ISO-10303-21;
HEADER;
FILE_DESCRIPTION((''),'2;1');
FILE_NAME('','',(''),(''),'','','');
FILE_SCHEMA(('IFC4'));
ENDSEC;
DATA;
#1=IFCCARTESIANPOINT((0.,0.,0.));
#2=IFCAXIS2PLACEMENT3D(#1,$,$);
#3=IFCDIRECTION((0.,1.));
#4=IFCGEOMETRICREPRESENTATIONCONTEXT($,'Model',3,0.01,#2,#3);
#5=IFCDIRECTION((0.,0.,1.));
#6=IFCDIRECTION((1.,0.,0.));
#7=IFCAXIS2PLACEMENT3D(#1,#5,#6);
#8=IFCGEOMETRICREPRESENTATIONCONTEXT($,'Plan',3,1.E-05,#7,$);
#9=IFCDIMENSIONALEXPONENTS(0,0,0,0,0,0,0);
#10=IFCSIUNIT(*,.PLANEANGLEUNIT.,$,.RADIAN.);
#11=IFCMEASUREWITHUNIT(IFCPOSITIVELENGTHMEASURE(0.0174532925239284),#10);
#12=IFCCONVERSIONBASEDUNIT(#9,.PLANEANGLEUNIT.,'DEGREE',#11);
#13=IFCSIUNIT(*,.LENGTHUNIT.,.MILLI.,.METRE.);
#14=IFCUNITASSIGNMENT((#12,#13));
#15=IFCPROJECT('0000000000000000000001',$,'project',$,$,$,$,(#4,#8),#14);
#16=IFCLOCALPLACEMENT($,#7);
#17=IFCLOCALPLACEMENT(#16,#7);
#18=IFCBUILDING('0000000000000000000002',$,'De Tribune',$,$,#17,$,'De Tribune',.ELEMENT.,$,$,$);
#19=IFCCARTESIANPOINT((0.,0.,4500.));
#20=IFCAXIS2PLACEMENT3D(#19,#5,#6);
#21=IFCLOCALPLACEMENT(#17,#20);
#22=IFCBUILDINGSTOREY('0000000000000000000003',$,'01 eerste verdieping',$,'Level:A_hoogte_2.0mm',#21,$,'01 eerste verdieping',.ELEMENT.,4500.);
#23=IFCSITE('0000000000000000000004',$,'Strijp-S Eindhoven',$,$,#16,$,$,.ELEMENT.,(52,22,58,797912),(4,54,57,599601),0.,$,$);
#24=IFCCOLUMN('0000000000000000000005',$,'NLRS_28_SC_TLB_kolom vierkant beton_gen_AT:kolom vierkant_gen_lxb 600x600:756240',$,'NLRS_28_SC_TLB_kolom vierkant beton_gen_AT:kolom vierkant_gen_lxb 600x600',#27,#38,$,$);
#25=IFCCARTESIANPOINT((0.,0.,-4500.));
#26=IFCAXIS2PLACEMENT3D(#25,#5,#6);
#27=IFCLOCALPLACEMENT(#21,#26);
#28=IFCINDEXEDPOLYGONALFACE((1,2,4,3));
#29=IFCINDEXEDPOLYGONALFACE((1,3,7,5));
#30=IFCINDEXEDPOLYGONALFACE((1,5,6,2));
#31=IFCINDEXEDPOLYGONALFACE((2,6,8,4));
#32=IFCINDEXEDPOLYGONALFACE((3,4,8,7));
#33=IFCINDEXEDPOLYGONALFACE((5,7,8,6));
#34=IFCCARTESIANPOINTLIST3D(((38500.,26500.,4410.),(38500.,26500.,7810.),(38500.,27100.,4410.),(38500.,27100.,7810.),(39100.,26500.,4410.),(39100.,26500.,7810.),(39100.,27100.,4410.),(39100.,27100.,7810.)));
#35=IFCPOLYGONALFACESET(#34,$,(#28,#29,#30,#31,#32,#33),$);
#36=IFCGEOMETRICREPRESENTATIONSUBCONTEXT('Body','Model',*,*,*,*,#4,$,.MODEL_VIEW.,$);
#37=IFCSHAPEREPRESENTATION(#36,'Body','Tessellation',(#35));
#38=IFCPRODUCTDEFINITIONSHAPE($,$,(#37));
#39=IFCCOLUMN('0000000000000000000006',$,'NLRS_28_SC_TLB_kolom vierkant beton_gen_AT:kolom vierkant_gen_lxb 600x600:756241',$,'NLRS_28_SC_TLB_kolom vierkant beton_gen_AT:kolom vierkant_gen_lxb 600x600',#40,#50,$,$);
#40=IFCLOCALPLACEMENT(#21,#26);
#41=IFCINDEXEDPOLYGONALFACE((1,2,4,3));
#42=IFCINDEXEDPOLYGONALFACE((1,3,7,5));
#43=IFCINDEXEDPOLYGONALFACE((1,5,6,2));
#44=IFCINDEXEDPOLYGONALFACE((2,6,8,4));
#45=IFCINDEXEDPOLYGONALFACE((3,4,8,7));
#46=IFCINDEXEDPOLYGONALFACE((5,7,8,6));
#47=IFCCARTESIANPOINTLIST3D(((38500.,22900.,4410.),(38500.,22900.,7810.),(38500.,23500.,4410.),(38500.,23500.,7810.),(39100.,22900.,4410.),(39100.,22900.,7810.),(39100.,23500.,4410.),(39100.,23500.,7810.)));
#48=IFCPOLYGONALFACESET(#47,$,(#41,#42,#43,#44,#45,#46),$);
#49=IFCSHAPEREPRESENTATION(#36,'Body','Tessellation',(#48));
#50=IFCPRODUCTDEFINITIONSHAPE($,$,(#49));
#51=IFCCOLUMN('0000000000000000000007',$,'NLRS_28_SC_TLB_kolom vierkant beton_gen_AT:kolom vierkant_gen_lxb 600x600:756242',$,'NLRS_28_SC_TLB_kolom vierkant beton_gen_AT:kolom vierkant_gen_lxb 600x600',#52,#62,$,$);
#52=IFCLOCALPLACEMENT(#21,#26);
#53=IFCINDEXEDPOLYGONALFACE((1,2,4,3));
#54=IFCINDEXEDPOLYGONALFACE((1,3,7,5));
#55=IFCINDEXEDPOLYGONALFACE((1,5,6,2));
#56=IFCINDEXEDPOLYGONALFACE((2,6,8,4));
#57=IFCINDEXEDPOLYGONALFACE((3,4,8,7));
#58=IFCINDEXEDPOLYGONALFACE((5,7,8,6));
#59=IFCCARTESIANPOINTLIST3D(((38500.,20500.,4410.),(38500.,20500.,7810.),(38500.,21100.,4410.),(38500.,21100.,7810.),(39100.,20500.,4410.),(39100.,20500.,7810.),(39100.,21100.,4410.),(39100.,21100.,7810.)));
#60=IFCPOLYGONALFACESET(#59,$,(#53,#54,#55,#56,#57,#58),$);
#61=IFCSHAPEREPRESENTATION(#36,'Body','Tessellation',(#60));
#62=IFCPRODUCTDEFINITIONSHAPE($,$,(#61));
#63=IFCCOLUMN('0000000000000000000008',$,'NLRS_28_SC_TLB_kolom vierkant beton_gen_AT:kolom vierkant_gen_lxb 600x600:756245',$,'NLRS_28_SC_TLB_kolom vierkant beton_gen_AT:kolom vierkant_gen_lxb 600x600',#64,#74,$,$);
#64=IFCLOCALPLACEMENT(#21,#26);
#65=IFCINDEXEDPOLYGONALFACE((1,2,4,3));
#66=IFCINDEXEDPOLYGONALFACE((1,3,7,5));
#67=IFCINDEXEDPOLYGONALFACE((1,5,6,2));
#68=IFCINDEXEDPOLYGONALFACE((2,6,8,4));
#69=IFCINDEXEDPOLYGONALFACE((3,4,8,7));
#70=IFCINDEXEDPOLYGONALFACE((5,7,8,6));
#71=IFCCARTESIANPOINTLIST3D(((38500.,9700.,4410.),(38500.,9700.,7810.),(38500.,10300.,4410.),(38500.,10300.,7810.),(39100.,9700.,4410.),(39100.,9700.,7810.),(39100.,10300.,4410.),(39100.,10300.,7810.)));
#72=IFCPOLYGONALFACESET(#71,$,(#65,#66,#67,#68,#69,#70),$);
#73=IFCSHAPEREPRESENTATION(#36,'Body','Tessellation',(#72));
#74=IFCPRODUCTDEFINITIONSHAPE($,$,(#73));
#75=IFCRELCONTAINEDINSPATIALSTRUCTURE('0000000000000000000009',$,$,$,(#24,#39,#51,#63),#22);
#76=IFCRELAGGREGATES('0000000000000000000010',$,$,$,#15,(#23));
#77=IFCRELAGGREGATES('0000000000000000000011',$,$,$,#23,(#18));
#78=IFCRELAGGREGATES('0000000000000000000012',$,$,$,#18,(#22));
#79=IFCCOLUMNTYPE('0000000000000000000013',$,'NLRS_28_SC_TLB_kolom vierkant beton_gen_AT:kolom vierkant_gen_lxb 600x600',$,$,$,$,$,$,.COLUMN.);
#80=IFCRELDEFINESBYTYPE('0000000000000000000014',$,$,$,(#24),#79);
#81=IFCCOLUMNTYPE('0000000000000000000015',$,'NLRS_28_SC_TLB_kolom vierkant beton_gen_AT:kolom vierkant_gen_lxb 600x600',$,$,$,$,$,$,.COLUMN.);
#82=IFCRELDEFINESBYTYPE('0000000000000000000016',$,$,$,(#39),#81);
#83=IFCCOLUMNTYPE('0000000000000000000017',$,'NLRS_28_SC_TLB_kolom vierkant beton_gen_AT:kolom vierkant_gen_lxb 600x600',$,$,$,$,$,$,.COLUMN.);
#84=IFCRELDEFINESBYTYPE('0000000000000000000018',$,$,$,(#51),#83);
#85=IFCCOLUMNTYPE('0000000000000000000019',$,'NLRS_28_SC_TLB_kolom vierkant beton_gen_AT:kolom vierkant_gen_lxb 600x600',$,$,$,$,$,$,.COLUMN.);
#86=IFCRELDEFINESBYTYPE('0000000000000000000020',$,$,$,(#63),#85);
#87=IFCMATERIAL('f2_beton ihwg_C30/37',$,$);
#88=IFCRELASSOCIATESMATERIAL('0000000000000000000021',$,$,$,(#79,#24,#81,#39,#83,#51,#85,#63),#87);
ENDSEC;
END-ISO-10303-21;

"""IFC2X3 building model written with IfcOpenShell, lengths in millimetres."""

from ifc_helpers import new_model, entity, si_unit, converted_unit, direction, frame, frame_2d, origin, origin_with_axes, place, context, subcontext, project, spatial, rectangle, extrude, source, transform, mapped, material, type_object, element, save


model = new_model("IFC2X3")

# Units and contexts
model_context = context("Model", 3, precision=0.01, world=origin(), true_north=direction((0.0, 1.0)))
plan_context = context("Plan", 3, precision=1e-05, world=origin_with_axes())
body_context = subcontext(model_context, "Body", "Model", "MODEL_VIEW")
ifc_project = project(units=[converted_unit("PLANEANGLEUNIT", "DEGREE", entity("IfcPositiveLengthMeasure", 0.0174532925239284), si_unit("PLANEANGLEUNIT", "RADIAN"), dimensions=[0, 0, 0, 0, 0, 0, 0]), si_unit("LENGTHUNIT", "METRE", prefix="MILLI")], contexts=[model_context, plan_context])

# Site, building, storey
site_placement = place(None, origin_with_axes())
site = spatial("IfcSite", under=ifc_project, at=site_placement, Name="Strijp-S Eindhoven", CompositionType="ELEMENT", RefLatitude=(52, 22, 58, 797912), RefLongitude=(4, 54, 57, 599601), RefElevation=0.0)
building_placement = place(site_placement, origin_with_axes())
building = spatial("IfcBuilding", under=site, at=building_placement, Name="De Tribune", LongName="De Tribune", CompositionType="ELEMENT")
storey_placement = place(building_placement, frame((0.0, 0.0, 4500.0), z_axis=(0.0, 0.0, 1.0), x_axis=(1.0, 0.0, 0.0)))
storey = spatial("IfcBuildingStorey", under=building, at=storey_placement, Name="01 eerste verdieping", ObjectType="Level:A_hoogte_2.0mm", LongName="01 eerste verdieping", CompositionType="ELEMENT", Elevation=4500.0)

# Columns
ifc_material = material(Name="f2_beton ihwg_C30/37")
column_type_1 = type_object("IfcColumnType", Name="NLRS_28_SC_TLB_kolom vierkant beton_gen_AT:kolom vierkant_gen_lxb 600x600", PredefinedType="COLUMN", material=ifc_material)
shared_shape_1 = source(origin(), body_context, "Body", "SweptSolid", [
    extrude(rectangle(XDim=600.0, YDim=600.0, at=frame_2d((0.0, 0.0), x_axis=(1.0, 0.0))), frame((38800.0, 26800.0, 4410.0), z_axis=(0.0, 0.0, 1.0), x_axis=(-1.0, 0.0, 0.0)), (0.0, 0.0, 1.0), 3400.0),
])
column_1_placement = place(storey_placement, frame((0.0, 0.0, -4500.0), z_axis=(0.0, 0.0, 1.0), x_axis=(1.0, 0.0, 0.0)))
element("IfcColumn", 1, at=column_1_placement, inside=storey, type_object=column_type_1, material=ifc_material, Name="NLRS_28_SC_TLB_kolom vierkant beton_gen_AT:kolom vierkant_gen_lxb 600x600:756240", ObjectType="NLRS_28_SC_TLB_kolom vierkant beton_gen_AT:kolom vierkant_gen_lxb 600x600", context=body_context, shape_type="MappedRepresentation", body=[
    mapped(shared_shape_1, transform((0.0, 0.0, 0.0), scale=1.0)),
])
column_type_2 = type_object("IfcColumnType", Name="NLRS_28_SC_TLB_kolom vierkant beton_gen_AT:kolom vierkant_gen_lxb 600x600", PredefinedType="COLUMN", material=ifc_material)
shared_shape_2 = source(origin(), body_context, "Body", "SweptSolid", [
    extrude(rectangle(XDim=600.0, YDim=600.0, at=frame_2d((0.0, 0.0), x_axis=(1.0, 0.0))), frame((38800.0, 23200.0, 4410.0), z_axis=(0.0, 0.0, 1.0), x_axis=(-1.0, 0.0, 0.0)), (0.0, 0.0, 1.0), 3400.0),
])
column_2_placement = place(storey_placement, frame((0.0, 0.0, -4500.0), z_axis=(0.0, 0.0, 1.0), x_axis=(1.0, 0.0, 0.0)))
element("IfcColumn", 2, at=column_2_placement, inside=storey, type_object=column_type_2, material=ifc_material, Name="NLRS_28_SC_TLB_kolom vierkant beton_gen_AT:kolom vierkant_gen_lxb 600x600:756241", ObjectType="NLRS_28_SC_TLB_kolom vierkant beton_gen_AT:kolom vierkant_gen_lxb 600x600", context=body_context, shape_type="MappedRepresentation", body=[
    mapped(shared_shape_2, transform((0.0, 0.0, 0.0), scale=1.0)),
])
column_type_3 = type_object("IfcColumnType", Name="NLRS_28_SC_TLB_kolom vierkant beton_gen_AT:kolom vierkant_gen_lxb 600x600", PredefinedType="COLUMN", material=ifc_material)
shared_shape_3 = source(origin(), body_context, "Body", "SweptSolid", [
    extrude(rectangle(XDim=600.0, YDim=600.0, at=frame_2d((0.0, 0.0), x_axis=(1.0, 0.0))), frame((38800.0, 20800.0, 4410.0), z_axis=(0.0, 0.0, 1.0), x_axis=(-1.0, 0.0, 0.0)), (0.0, 0.0, 1.0), 3400.0),
])
column_3_placement = place(storey_placement, frame((0.0, 0.0, -4500.0), z_axis=(0.0, 0.0, 1.0), x_axis=(1.0, 0.0, 0.0)))
element("IfcColumn", 3, at=column_3_placement, inside=storey, type_object=column_type_3, material=ifc_material, Name="NLRS_28_SC_TLB_kolom vierkant beton_gen_AT:kolom vierkant_gen_lxb 600x600:756242", ObjectType="NLRS_28_SC_TLB_kolom vierkant beton_gen_AT:kolom vierkant_gen_lxb 600x600", context=body_context, shape_type="MappedRepresentation", body=[
    mapped(shared_shape_3, transform((0.0, 0.0, 0.0), scale=1.0)),
])
column_type_4 = type_object("IfcColumnType", Name="NLRS_28_SC_TLB_kolom vierkant beton_gen_AT:kolom vierkant_gen_lxb 600x600", PredefinedType="COLUMN", material=ifc_material)
shared_shape_4 = source(origin(), body_context, "Body", "SweptSolid", [
    extrude(rectangle(XDim=600.0, YDim=600.0, at=frame_2d((0.0, 0.0), x_axis=(1.0, 0.0))), frame((38800.0, 10000.0, 4410.0), z_axis=(0.0, 0.0, 1.0), x_axis=(0.0, -1.0, 0.0)), (0.0, 0.0, 1.0), 3400.0),
])
column_4_placement = place(storey_placement, frame((0.0, 0.0, -4500.0), z_axis=(0.0, 0.0, 1.0), x_axis=(1.0, 0.0, 0.0)))
element("IfcColumn", 4, at=column_4_placement, inside=storey, type_object=column_type_4, material=ifc_material, Name="NLRS_28_SC_TLB_kolom vierkant beton_gen_AT:kolom vierkant_gen_lxb 600x600:756245", ObjectType="NLRS_28_SC_TLB_kolom vierkant beton_gen_AT:kolom vierkant_gen_lxb 600x600", context=body_context, shape_type="MappedRepresentation", body=[
    mapped(shared_shape_4, transform((0.0, 0.0, 0.0), scale=1.0)),
])

save(model, "model.ifc")
